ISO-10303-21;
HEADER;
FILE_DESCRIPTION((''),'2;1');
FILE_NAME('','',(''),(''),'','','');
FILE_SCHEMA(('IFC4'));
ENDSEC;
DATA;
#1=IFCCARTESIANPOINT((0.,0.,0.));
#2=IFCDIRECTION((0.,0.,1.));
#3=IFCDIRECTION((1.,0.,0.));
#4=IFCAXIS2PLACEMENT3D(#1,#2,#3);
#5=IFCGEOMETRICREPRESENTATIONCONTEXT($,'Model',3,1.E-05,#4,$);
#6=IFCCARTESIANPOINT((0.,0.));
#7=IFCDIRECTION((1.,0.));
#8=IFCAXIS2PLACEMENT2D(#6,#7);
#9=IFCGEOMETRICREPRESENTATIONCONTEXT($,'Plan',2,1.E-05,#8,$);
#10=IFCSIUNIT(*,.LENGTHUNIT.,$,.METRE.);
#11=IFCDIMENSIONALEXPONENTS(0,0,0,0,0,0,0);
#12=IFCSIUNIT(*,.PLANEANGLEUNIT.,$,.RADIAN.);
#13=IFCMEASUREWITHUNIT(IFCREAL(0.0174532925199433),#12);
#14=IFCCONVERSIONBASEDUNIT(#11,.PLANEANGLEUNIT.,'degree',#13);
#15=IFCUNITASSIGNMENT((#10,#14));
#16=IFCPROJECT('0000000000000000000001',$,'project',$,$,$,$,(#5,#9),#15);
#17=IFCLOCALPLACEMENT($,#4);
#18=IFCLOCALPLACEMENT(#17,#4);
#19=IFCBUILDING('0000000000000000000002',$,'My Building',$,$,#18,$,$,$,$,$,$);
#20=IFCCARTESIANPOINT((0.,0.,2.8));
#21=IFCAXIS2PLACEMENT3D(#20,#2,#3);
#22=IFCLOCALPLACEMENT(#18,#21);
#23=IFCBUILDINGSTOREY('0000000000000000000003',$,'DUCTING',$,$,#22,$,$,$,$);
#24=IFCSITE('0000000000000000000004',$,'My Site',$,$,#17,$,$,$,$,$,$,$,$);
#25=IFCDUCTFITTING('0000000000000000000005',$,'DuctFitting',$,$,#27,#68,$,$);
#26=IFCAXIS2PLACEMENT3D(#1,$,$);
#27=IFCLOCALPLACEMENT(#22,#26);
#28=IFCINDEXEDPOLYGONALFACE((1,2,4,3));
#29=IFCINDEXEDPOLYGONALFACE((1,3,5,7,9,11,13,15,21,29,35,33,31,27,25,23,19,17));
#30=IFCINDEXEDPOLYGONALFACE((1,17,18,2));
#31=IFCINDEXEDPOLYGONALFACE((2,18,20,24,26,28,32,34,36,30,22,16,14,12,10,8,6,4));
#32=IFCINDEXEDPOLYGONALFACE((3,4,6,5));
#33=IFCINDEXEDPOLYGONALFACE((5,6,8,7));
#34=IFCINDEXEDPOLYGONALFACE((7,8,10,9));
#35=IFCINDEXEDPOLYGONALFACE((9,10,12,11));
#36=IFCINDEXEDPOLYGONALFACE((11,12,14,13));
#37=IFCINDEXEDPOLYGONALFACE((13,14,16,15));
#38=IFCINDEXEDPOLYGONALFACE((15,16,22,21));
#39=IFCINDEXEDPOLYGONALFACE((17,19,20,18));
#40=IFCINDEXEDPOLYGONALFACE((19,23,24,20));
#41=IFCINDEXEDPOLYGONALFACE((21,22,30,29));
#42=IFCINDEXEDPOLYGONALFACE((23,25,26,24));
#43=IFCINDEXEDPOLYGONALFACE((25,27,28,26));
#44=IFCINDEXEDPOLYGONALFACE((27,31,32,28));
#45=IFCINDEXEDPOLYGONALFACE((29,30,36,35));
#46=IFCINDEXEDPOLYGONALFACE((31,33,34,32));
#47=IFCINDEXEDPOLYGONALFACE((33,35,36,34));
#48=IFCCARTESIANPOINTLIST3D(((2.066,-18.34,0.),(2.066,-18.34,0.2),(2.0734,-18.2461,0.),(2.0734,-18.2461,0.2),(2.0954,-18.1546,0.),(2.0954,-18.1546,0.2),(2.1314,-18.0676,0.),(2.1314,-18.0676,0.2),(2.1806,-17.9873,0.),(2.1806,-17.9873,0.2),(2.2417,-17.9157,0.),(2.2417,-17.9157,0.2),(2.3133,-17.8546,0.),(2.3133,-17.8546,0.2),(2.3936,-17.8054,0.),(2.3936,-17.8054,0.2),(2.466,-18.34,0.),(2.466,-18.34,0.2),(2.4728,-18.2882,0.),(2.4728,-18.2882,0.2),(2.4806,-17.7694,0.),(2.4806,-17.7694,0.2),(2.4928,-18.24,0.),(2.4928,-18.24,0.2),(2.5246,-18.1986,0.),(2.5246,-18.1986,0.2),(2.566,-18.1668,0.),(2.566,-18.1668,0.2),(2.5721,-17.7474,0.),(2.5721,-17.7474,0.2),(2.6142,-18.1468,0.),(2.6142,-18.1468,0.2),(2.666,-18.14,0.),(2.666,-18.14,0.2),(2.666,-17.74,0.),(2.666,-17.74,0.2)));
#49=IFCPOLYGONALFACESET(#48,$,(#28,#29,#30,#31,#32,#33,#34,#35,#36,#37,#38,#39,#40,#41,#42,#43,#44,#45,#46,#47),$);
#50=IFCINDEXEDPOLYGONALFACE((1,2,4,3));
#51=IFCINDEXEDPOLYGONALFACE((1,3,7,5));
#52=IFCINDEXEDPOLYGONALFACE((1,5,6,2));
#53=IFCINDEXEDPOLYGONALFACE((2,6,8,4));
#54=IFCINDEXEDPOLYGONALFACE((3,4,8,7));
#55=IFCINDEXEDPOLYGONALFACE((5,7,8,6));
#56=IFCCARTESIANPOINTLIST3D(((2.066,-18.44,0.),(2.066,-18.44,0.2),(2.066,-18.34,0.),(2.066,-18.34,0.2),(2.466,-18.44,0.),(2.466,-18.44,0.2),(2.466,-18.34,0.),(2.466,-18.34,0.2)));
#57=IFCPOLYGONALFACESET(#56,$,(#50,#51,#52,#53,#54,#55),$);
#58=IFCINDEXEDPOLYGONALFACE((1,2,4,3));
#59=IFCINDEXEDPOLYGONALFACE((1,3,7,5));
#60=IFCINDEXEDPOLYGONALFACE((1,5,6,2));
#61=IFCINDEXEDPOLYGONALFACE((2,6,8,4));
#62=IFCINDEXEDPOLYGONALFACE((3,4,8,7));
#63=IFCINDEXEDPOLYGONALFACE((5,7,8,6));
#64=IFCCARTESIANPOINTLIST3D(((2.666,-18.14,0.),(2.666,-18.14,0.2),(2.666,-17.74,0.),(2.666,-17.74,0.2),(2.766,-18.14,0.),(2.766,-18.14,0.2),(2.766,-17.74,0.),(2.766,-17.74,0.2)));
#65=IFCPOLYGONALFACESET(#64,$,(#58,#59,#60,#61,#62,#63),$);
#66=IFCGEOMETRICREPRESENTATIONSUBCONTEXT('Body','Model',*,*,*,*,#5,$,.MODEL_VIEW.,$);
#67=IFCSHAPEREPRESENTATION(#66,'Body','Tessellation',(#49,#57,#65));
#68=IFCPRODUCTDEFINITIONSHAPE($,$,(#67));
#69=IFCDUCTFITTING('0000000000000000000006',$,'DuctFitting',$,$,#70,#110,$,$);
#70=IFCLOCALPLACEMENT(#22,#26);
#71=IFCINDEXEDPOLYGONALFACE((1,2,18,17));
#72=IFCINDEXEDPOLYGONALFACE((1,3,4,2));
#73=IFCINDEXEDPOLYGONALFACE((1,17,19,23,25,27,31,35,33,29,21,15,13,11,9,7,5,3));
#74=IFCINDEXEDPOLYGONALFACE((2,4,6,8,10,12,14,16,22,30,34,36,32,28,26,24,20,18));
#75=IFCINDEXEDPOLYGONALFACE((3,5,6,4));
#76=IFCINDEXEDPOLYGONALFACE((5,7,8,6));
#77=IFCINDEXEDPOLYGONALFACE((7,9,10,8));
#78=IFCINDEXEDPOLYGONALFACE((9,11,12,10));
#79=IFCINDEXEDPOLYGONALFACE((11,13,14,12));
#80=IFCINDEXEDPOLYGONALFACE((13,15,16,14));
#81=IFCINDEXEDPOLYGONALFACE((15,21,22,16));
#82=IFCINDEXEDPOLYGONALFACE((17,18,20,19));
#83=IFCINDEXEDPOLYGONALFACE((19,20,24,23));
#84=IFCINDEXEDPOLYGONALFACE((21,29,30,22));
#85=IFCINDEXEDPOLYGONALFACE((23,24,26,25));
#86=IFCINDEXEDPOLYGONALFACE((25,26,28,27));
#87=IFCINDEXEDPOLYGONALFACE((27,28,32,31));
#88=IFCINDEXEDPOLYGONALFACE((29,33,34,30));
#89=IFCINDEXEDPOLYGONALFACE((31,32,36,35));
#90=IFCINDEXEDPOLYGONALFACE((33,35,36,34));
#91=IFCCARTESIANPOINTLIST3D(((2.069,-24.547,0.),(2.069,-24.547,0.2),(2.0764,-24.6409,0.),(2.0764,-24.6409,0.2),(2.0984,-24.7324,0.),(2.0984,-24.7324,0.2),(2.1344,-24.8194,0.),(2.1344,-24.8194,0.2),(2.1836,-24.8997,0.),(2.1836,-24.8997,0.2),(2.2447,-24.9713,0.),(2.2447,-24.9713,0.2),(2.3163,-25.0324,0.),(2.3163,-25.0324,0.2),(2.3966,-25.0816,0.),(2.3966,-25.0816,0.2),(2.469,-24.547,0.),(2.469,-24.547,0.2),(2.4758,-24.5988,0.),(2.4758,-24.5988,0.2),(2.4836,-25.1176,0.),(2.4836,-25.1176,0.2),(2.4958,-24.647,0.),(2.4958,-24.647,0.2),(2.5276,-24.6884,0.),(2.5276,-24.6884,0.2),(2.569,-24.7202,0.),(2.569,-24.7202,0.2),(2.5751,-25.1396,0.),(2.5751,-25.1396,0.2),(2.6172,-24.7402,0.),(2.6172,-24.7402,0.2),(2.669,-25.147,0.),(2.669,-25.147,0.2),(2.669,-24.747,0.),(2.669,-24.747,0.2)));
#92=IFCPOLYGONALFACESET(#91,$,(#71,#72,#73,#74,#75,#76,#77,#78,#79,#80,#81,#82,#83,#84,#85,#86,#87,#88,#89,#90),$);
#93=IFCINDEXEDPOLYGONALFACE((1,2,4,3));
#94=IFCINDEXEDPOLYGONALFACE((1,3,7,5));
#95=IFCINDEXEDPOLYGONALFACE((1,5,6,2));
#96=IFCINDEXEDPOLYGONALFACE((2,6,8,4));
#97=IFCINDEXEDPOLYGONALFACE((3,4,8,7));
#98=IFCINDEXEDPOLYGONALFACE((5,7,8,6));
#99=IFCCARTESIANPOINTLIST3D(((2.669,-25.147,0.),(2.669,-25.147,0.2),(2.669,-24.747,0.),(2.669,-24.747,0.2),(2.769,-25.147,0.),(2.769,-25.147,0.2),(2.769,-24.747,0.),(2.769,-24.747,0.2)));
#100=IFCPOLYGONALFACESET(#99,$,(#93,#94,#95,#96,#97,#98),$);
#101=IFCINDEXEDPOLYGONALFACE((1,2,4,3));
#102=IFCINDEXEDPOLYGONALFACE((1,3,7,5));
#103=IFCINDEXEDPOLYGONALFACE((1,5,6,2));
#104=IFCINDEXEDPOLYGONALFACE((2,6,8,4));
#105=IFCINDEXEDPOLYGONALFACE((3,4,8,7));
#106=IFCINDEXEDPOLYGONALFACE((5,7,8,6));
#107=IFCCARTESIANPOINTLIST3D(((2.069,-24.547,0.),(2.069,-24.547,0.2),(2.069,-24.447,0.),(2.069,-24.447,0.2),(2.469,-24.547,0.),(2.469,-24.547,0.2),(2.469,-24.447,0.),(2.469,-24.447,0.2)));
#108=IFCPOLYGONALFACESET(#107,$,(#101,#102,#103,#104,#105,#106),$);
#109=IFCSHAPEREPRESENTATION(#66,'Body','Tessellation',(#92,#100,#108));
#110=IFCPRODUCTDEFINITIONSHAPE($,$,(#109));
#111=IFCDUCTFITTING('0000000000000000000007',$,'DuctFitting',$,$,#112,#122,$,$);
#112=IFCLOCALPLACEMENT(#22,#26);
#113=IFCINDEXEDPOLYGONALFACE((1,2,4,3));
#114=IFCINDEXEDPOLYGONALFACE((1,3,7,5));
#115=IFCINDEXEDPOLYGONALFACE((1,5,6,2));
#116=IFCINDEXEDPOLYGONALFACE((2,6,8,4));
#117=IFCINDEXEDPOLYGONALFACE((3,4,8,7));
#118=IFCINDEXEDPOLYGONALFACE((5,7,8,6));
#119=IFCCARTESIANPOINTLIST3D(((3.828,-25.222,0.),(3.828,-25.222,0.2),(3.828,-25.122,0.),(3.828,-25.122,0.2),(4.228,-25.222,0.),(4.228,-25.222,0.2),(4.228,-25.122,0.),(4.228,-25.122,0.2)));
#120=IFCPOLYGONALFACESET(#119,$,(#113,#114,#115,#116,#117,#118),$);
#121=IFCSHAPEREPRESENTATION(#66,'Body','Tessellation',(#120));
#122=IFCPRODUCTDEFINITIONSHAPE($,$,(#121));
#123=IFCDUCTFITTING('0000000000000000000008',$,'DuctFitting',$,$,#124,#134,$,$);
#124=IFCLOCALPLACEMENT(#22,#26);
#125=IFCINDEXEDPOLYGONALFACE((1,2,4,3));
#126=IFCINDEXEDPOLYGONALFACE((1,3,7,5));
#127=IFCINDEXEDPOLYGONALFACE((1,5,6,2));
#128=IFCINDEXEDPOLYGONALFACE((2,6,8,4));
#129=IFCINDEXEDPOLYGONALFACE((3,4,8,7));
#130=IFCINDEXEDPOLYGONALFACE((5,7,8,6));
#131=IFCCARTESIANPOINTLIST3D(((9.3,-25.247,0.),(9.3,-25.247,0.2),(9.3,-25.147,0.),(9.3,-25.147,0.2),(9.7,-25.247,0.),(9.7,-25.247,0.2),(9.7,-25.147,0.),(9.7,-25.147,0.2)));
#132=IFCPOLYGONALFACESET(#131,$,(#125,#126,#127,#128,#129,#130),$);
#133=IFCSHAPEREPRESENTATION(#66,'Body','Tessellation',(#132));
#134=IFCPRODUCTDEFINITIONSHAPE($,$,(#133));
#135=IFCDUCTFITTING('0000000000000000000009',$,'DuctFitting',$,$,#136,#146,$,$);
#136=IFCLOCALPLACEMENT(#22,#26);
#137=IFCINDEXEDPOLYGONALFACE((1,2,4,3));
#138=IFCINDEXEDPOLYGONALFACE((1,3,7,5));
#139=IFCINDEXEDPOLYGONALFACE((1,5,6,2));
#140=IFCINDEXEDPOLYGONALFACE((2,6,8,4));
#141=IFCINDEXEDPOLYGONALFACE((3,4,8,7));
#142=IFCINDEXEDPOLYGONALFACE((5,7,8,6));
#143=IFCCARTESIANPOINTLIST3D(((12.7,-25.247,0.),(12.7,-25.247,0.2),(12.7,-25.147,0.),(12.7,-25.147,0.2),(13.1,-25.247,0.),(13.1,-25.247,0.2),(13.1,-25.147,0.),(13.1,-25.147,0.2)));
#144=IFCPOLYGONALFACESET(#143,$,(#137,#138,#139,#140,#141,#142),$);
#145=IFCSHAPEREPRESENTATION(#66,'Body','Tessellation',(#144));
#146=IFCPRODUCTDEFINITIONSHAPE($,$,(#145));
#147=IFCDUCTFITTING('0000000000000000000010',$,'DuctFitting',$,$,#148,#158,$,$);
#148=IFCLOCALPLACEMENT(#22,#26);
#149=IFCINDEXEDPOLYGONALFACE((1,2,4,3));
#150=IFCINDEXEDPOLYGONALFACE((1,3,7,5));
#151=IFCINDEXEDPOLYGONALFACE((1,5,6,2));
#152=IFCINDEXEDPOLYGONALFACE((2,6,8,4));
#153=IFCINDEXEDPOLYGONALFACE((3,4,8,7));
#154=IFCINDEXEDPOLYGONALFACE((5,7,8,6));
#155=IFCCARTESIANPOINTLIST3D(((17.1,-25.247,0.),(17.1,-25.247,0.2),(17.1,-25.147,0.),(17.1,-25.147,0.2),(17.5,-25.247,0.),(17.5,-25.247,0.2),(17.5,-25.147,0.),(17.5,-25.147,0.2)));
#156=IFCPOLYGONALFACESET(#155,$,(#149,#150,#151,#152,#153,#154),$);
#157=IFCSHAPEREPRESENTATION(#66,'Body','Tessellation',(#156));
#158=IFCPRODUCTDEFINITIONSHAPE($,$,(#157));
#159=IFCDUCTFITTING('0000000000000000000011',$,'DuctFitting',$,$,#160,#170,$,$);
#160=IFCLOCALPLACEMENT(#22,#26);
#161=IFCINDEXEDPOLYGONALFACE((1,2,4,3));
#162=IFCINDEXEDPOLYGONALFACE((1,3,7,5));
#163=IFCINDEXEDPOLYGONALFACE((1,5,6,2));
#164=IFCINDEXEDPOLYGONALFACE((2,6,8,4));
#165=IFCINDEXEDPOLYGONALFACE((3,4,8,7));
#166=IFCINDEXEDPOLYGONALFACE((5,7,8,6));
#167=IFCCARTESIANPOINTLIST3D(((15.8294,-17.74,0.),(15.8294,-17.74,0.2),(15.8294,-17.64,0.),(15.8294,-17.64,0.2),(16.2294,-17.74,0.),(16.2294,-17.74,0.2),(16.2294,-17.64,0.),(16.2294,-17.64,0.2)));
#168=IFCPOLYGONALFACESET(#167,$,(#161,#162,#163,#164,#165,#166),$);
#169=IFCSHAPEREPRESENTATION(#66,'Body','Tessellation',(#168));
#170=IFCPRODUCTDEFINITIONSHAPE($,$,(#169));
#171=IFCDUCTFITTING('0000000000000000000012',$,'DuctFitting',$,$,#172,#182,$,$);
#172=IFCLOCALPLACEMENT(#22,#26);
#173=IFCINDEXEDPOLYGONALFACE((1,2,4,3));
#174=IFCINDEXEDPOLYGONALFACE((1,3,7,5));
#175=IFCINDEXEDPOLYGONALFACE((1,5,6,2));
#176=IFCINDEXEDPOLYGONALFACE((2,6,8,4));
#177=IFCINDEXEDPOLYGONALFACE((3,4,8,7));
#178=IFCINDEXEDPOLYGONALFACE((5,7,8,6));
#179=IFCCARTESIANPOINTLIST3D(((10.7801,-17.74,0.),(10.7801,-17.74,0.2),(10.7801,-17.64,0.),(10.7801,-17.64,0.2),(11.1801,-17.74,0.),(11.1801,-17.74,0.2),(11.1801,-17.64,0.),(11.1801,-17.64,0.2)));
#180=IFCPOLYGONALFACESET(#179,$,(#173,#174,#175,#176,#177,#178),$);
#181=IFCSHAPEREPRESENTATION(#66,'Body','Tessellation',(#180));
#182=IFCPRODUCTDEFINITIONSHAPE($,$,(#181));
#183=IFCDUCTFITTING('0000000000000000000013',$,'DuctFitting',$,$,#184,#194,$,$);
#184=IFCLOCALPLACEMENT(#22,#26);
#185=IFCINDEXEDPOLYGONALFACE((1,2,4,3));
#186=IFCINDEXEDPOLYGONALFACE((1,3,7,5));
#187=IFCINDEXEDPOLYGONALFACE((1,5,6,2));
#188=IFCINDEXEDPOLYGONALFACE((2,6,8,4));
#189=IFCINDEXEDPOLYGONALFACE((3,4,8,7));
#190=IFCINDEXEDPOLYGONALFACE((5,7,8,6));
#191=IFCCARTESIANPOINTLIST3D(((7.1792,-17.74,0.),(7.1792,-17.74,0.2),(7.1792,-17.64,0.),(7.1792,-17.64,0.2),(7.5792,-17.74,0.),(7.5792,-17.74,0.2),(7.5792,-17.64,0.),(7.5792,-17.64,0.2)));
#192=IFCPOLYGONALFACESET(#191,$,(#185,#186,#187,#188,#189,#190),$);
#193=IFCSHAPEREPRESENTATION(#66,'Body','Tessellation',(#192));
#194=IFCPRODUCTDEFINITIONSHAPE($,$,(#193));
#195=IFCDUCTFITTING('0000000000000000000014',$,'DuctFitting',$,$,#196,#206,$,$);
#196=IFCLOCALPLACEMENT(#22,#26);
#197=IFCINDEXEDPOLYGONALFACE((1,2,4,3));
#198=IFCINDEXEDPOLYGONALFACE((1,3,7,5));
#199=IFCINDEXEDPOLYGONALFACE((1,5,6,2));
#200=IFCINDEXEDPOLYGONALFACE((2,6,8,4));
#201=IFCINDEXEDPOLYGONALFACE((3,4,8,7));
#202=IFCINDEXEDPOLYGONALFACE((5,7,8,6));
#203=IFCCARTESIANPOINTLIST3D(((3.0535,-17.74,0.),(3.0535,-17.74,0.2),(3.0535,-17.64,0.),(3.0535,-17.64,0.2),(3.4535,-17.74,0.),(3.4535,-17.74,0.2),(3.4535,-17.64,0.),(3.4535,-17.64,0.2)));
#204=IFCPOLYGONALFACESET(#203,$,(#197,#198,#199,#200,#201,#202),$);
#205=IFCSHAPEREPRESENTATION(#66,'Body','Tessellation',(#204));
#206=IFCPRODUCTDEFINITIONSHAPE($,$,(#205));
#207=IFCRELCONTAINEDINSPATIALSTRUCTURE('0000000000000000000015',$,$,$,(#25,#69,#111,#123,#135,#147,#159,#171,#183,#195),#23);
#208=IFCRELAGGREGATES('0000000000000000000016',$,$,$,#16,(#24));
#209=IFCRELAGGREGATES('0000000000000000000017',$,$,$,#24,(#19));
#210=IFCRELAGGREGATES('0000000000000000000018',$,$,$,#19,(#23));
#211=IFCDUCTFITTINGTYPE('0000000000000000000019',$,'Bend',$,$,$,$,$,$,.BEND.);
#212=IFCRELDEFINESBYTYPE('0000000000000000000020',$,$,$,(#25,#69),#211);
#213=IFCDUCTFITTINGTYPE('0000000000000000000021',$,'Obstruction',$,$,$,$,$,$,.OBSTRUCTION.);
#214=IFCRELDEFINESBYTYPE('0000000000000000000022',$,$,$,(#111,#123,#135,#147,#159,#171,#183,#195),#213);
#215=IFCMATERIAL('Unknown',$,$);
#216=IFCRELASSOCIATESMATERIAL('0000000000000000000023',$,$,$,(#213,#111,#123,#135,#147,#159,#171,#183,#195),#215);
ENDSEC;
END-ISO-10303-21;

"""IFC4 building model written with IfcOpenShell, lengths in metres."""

from ifc_helpers import new_model, entity, si_unit, converted_unit, frame, origin_with_axes, origin_2d_with_axis, place, context, subcontext, project, spatial, line, arc, indexed_curve, rectangle, outline, extrude, source, transform, mapped, material, material_profile, profile_set, profile_usage, type_object, type_shapes, element, save


model = new_model("IFC4")

# Units and contexts
model_context = context("Model", 3, precision=1e-05, world=origin_with_axes())
plan_context = context("Plan", 2, precision=1e-05, world=origin_2d_with_axis())
body_context = subcontext(model_context, "Body", "Model", "MODEL_VIEW")
ifc_project = project(units=[si_unit("LENGTHUNIT", "METRE"), converted_unit("PLANEANGLEUNIT", "degree", entity("IfcReal", 0.0174532925199433), si_unit("PLANEANGLEUNIT", "RADIAN"), dimensions=[0, 0, 0, 0, 0, 0, 0])], contexts=[model_context, plan_context])

# Site, building, storey
site_placement = place(None, origin_with_axes())
site = spatial("IfcSite", under=ifc_project, at=site_placement, Name="My Site")
building_placement = place(site_placement, origin_with_axes())
building = spatial("IfcBuilding", under=site, at=building_placement, Name="My Building")
storey_placement = place(building_placement, frame((0.0, 0.0, 2.8), z_axis=(0.0, 0.0, 1.0), x_axis=(1.0, 0.0, 0.0)))
storey = spatial("IfcBuildingStorey", under=building, at=storey_placement, Name="DUCTING")

# Shared definitions
ifc_material = material(Name="Unknown")

# Duct fittings
duct_fitting_type_1 = type_object("IfcDuctFittingType", Name="Bend", PredefinedType="BEND")
shared_shape = source(origin_with_axes(), body_context, "Body", "SweptSolid", [
    extrude(outline(indexed_curve([(-0.2, 0.0), (-0.2586, 0.1414), (-0.4, 0.2), (-0.4, 0.6), (0.0243, 0.4243), (0.2, 0.0)], segments=[arc(1, 2, 3), line(3, 4), arc(4, 5, 6), line(6, 1)])), frame((0.0, -0.1, 0.1), z_axis=(0.0, -1.0, 0.0), x_axis=(1.0, 0.0, 0.0)), (0.0, 0.0, -1.0), 0.2),
    extrude(rectangle(XDim=0.4, YDim=0.2), origin_with_axes(), (0.0, 0.0, 1.0), 0.1),
    extrude(rectangle(XDim=0.4, YDim=0.2), frame((-0.4, 0.0, 0.5), z_axis=(-1.0, 0.0, 0.0), x_axis=(0.0, 0.0, -1.0)), (0.0, 0.0, 1.0), 0.1),
])
type_shapes(duct_fitting_type_1, [shared_shape])
for number, where, z_axis, x_axis, name in (
    (1, (2.266, -18.44, 0.1), (0.0, 1.0, 0.0), (-1.0, 0.0, 0.0), "DuctFitting"),
    (2, (2.769, -24.947, 0.1), (-1.0, 0.0, 0.0), (0.0, -1.0, 0.0), "DuctFitting"),
):
    element("IfcDuctFitting", number, at=place(storey_placement, frame(where, z_axis=z_axis, x_axis=x_axis)), inside=storey, type_object=duct_fitting_type_1, Name=name, context=body_context, shape_type="MappedRepresentation", body=[
        mapped(shared_shape, transform((0.0, 0.0, 0.0), x_axis=(1.0, 0.0, 0.0), y_axis=(0.0, 1.0, 0.0), z_axis=(0.0, 0.0, 1.0), scale=1.0)),
    ])
ifc_material_profile_1 = material_profile(ifc_material, rectangle(XDim=0.4, YDim=0.2))
ifc_profile_set_1 = profile_set([ifc_material_profile_1])
ifc_profile_usage_1 = profile_usage(ifc_profile_set_1, cardinal=5)
duct_fitting_type_2 = type_object("IfcDuctFittingType", Name="Obstruction", PredefinedType="OBSTRUCTION", material=ifc_profile_set_1)
duct_fitting_1_placement = place(storey_placement, frame((4.028, -25.122, 0.1), z_axis=(0.0, -1.0, -0.000004), x_axis=(1.0, 0.0, 0.0)))
element("IfcDuctFitting", 3, at=duct_fitting_1_placement, inside=storey, type_object=duct_fitting_type_2, material=ifc_profile_usage_1, Name="DuctFitting", context=body_context, shape_type="SweptSolid", body=[
    extrude(rectangle(XDim=0.4, YDim=0.2), origin_with_axes(), (0.0, 0.0, 1.0), 0.1),
])
ifc_profile_usage_2 = profile_usage(ifc_profile_set_1, cardinal=5)
duct_fitting_2_placement = place(storey_placement, frame((9.5, -25.147, 0.1), z_axis=(0.0, -1.0, -0.000004), x_axis=(1.0, 0.0, 0.0)))
element("IfcDuctFitting", 4, at=duct_fitting_2_placement, inside=storey, type_object=duct_fitting_type_2, material=ifc_profile_usage_2, Name="DuctFitting", context=body_context, shape_type="SweptSolid", body=[
    extrude(rectangle(XDim=0.4, YDim=0.2), origin_with_axes(), (0.0, 0.0, 1.0), 0.1),
])
ifc_profile_usage_3 = profile_usage(ifc_profile_set_1, cardinal=5)
duct_fitting_3_placement = place(storey_placement, frame((12.9, -25.147, 0.1), z_axis=(0.0, -1.0, -0.000004), x_axis=(1.0, 0.0, 0.0)))
element("IfcDuctFitting", 5, at=duct_fitting_3_placement, inside=storey, type_object=duct_fitting_type_2, material=ifc_profile_usage_3, Name="DuctFitting", context=body_context, shape_type="SweptSolid", body=[
    extrude(rectangle(XDim=0.4, YDim=0.2), origin_with_axes(), (0.0, 0.0, 1.0), 0.1),
])
ifc_profile_usage_4 = profile_usage(ifc_profile_set_1, cardinal=5)
duct_fitting_4_placement = place(storey_placement, frame((17.3, -25.147, 0.1), z_axis=(0.0, -1.0, -0.000004), x_axis=(1.0, 0.0, 0.0)))
element("IfcDuctFitting", 6, at=duct_fitting_4_placement, inside=storey, type_object=duct_fitting_type_2, material=ifc_profile_usage_4, Name="DuctFitting", context=body_context, shape_type="SweptSolid", body=[
    extrude(rectangle(XDim=0.4, YDim=0.2), origin_with_axes(), (0.0, 0.0, 1.0), 0.1),
])
ifc_profile_usage_5 = profile_usage(ifc_profile_set_1, cardinal=5)
duct_fitting_5_placement = place(storey_placement, frame((16.0294, -17.74, 0.1), z_axis=(0.0, 1.0, -0.000004), x_axis=(-1.0, 0.0, 0.0)))
element("IfcDuctFitting", 7, at=duct_fitting_5_placement, inside=storey, type_object=duct_fitting_type_2, material=ifc_profile_usage_5, Name="DuctFitting", context=body_context, shape_type="SweptSolid", body=[
    extrude(rectangle(XDim=0.4, YDim=0.2), origin_with_axes(), (0.0, 0.0, 1.0), 0.1),
])
ifc_profile_usage_6 = profile_usage(ifc_profile_set_1, cardinal=5)
duct_fitting_6_placement = place(storey_placement, frame((10.9801, -17.74, 0.1), z_axis=(0.0, 1.0, -0.000004), x_axis=(-1.0, 0.0, 0.0)))
element("IfcDuctFitting", 8, at=duct_fitting_6_placement, inside=storey, type_object=duct_fitting_type_2, material=ifc_profile_usage_6, Name="DuctFitting", context=body_context, shape_type="SweptSolid", body=[
    extrude(rectangle(XDim=0.4, YDim=0.2), origin_with_axes(), (0.0, 0.0, 1.0), 0.1),
])
ifc_profile_usage_7 = profile_usage(ifc_profile_set_1, cardinal=5)
duct_fitting_7_placement = place(storey_placement, frame((7.3792, -17.74, 0.1), z_axis=(0.0, 1.0, -0.000004), x_axis=(-1.0, 0.0, 0.0)))
element("IfcDuctFitting", 9, at=duct_fitting_7_placement, inside=storey, type_object=duct_fitting_type_2, material=ifc_profile_usage_7, Name="DuctFitting", context=body_context, shape_type="SweptSolid", body=[
    extrude(rectangle(XDim=0.4, YDim=0.2), origin_with_axes(), (0.0, 0.0, 1.0), 0.1),
])
ifc_profile_usage_8 = profile_usage(ifc_profile_set_1, cardinal=5)
duct_fitting_8_placement = place(storey_placement, frame((3.2535, -17.74, 0.1), z_axis=(0.0, 1.0, -0.000004), x_axis=(-1.0, 0.0, 0.0)))
element("IfcDuctFitting", 10, at=duct_fitting_8_placement, inside=storey, type_object=duct_fitting_type_2, material=ifc_profile_usage_8, Name="DuctFitting", context=body_context, shape_type="SweptSolid", body=[
    extrude(rectangle(XDim=0.4, YDim=0.2), origin_with_axes(), (0.0, 0.0, 1.0), 0.1),
])

save(model, "model.ifc")
